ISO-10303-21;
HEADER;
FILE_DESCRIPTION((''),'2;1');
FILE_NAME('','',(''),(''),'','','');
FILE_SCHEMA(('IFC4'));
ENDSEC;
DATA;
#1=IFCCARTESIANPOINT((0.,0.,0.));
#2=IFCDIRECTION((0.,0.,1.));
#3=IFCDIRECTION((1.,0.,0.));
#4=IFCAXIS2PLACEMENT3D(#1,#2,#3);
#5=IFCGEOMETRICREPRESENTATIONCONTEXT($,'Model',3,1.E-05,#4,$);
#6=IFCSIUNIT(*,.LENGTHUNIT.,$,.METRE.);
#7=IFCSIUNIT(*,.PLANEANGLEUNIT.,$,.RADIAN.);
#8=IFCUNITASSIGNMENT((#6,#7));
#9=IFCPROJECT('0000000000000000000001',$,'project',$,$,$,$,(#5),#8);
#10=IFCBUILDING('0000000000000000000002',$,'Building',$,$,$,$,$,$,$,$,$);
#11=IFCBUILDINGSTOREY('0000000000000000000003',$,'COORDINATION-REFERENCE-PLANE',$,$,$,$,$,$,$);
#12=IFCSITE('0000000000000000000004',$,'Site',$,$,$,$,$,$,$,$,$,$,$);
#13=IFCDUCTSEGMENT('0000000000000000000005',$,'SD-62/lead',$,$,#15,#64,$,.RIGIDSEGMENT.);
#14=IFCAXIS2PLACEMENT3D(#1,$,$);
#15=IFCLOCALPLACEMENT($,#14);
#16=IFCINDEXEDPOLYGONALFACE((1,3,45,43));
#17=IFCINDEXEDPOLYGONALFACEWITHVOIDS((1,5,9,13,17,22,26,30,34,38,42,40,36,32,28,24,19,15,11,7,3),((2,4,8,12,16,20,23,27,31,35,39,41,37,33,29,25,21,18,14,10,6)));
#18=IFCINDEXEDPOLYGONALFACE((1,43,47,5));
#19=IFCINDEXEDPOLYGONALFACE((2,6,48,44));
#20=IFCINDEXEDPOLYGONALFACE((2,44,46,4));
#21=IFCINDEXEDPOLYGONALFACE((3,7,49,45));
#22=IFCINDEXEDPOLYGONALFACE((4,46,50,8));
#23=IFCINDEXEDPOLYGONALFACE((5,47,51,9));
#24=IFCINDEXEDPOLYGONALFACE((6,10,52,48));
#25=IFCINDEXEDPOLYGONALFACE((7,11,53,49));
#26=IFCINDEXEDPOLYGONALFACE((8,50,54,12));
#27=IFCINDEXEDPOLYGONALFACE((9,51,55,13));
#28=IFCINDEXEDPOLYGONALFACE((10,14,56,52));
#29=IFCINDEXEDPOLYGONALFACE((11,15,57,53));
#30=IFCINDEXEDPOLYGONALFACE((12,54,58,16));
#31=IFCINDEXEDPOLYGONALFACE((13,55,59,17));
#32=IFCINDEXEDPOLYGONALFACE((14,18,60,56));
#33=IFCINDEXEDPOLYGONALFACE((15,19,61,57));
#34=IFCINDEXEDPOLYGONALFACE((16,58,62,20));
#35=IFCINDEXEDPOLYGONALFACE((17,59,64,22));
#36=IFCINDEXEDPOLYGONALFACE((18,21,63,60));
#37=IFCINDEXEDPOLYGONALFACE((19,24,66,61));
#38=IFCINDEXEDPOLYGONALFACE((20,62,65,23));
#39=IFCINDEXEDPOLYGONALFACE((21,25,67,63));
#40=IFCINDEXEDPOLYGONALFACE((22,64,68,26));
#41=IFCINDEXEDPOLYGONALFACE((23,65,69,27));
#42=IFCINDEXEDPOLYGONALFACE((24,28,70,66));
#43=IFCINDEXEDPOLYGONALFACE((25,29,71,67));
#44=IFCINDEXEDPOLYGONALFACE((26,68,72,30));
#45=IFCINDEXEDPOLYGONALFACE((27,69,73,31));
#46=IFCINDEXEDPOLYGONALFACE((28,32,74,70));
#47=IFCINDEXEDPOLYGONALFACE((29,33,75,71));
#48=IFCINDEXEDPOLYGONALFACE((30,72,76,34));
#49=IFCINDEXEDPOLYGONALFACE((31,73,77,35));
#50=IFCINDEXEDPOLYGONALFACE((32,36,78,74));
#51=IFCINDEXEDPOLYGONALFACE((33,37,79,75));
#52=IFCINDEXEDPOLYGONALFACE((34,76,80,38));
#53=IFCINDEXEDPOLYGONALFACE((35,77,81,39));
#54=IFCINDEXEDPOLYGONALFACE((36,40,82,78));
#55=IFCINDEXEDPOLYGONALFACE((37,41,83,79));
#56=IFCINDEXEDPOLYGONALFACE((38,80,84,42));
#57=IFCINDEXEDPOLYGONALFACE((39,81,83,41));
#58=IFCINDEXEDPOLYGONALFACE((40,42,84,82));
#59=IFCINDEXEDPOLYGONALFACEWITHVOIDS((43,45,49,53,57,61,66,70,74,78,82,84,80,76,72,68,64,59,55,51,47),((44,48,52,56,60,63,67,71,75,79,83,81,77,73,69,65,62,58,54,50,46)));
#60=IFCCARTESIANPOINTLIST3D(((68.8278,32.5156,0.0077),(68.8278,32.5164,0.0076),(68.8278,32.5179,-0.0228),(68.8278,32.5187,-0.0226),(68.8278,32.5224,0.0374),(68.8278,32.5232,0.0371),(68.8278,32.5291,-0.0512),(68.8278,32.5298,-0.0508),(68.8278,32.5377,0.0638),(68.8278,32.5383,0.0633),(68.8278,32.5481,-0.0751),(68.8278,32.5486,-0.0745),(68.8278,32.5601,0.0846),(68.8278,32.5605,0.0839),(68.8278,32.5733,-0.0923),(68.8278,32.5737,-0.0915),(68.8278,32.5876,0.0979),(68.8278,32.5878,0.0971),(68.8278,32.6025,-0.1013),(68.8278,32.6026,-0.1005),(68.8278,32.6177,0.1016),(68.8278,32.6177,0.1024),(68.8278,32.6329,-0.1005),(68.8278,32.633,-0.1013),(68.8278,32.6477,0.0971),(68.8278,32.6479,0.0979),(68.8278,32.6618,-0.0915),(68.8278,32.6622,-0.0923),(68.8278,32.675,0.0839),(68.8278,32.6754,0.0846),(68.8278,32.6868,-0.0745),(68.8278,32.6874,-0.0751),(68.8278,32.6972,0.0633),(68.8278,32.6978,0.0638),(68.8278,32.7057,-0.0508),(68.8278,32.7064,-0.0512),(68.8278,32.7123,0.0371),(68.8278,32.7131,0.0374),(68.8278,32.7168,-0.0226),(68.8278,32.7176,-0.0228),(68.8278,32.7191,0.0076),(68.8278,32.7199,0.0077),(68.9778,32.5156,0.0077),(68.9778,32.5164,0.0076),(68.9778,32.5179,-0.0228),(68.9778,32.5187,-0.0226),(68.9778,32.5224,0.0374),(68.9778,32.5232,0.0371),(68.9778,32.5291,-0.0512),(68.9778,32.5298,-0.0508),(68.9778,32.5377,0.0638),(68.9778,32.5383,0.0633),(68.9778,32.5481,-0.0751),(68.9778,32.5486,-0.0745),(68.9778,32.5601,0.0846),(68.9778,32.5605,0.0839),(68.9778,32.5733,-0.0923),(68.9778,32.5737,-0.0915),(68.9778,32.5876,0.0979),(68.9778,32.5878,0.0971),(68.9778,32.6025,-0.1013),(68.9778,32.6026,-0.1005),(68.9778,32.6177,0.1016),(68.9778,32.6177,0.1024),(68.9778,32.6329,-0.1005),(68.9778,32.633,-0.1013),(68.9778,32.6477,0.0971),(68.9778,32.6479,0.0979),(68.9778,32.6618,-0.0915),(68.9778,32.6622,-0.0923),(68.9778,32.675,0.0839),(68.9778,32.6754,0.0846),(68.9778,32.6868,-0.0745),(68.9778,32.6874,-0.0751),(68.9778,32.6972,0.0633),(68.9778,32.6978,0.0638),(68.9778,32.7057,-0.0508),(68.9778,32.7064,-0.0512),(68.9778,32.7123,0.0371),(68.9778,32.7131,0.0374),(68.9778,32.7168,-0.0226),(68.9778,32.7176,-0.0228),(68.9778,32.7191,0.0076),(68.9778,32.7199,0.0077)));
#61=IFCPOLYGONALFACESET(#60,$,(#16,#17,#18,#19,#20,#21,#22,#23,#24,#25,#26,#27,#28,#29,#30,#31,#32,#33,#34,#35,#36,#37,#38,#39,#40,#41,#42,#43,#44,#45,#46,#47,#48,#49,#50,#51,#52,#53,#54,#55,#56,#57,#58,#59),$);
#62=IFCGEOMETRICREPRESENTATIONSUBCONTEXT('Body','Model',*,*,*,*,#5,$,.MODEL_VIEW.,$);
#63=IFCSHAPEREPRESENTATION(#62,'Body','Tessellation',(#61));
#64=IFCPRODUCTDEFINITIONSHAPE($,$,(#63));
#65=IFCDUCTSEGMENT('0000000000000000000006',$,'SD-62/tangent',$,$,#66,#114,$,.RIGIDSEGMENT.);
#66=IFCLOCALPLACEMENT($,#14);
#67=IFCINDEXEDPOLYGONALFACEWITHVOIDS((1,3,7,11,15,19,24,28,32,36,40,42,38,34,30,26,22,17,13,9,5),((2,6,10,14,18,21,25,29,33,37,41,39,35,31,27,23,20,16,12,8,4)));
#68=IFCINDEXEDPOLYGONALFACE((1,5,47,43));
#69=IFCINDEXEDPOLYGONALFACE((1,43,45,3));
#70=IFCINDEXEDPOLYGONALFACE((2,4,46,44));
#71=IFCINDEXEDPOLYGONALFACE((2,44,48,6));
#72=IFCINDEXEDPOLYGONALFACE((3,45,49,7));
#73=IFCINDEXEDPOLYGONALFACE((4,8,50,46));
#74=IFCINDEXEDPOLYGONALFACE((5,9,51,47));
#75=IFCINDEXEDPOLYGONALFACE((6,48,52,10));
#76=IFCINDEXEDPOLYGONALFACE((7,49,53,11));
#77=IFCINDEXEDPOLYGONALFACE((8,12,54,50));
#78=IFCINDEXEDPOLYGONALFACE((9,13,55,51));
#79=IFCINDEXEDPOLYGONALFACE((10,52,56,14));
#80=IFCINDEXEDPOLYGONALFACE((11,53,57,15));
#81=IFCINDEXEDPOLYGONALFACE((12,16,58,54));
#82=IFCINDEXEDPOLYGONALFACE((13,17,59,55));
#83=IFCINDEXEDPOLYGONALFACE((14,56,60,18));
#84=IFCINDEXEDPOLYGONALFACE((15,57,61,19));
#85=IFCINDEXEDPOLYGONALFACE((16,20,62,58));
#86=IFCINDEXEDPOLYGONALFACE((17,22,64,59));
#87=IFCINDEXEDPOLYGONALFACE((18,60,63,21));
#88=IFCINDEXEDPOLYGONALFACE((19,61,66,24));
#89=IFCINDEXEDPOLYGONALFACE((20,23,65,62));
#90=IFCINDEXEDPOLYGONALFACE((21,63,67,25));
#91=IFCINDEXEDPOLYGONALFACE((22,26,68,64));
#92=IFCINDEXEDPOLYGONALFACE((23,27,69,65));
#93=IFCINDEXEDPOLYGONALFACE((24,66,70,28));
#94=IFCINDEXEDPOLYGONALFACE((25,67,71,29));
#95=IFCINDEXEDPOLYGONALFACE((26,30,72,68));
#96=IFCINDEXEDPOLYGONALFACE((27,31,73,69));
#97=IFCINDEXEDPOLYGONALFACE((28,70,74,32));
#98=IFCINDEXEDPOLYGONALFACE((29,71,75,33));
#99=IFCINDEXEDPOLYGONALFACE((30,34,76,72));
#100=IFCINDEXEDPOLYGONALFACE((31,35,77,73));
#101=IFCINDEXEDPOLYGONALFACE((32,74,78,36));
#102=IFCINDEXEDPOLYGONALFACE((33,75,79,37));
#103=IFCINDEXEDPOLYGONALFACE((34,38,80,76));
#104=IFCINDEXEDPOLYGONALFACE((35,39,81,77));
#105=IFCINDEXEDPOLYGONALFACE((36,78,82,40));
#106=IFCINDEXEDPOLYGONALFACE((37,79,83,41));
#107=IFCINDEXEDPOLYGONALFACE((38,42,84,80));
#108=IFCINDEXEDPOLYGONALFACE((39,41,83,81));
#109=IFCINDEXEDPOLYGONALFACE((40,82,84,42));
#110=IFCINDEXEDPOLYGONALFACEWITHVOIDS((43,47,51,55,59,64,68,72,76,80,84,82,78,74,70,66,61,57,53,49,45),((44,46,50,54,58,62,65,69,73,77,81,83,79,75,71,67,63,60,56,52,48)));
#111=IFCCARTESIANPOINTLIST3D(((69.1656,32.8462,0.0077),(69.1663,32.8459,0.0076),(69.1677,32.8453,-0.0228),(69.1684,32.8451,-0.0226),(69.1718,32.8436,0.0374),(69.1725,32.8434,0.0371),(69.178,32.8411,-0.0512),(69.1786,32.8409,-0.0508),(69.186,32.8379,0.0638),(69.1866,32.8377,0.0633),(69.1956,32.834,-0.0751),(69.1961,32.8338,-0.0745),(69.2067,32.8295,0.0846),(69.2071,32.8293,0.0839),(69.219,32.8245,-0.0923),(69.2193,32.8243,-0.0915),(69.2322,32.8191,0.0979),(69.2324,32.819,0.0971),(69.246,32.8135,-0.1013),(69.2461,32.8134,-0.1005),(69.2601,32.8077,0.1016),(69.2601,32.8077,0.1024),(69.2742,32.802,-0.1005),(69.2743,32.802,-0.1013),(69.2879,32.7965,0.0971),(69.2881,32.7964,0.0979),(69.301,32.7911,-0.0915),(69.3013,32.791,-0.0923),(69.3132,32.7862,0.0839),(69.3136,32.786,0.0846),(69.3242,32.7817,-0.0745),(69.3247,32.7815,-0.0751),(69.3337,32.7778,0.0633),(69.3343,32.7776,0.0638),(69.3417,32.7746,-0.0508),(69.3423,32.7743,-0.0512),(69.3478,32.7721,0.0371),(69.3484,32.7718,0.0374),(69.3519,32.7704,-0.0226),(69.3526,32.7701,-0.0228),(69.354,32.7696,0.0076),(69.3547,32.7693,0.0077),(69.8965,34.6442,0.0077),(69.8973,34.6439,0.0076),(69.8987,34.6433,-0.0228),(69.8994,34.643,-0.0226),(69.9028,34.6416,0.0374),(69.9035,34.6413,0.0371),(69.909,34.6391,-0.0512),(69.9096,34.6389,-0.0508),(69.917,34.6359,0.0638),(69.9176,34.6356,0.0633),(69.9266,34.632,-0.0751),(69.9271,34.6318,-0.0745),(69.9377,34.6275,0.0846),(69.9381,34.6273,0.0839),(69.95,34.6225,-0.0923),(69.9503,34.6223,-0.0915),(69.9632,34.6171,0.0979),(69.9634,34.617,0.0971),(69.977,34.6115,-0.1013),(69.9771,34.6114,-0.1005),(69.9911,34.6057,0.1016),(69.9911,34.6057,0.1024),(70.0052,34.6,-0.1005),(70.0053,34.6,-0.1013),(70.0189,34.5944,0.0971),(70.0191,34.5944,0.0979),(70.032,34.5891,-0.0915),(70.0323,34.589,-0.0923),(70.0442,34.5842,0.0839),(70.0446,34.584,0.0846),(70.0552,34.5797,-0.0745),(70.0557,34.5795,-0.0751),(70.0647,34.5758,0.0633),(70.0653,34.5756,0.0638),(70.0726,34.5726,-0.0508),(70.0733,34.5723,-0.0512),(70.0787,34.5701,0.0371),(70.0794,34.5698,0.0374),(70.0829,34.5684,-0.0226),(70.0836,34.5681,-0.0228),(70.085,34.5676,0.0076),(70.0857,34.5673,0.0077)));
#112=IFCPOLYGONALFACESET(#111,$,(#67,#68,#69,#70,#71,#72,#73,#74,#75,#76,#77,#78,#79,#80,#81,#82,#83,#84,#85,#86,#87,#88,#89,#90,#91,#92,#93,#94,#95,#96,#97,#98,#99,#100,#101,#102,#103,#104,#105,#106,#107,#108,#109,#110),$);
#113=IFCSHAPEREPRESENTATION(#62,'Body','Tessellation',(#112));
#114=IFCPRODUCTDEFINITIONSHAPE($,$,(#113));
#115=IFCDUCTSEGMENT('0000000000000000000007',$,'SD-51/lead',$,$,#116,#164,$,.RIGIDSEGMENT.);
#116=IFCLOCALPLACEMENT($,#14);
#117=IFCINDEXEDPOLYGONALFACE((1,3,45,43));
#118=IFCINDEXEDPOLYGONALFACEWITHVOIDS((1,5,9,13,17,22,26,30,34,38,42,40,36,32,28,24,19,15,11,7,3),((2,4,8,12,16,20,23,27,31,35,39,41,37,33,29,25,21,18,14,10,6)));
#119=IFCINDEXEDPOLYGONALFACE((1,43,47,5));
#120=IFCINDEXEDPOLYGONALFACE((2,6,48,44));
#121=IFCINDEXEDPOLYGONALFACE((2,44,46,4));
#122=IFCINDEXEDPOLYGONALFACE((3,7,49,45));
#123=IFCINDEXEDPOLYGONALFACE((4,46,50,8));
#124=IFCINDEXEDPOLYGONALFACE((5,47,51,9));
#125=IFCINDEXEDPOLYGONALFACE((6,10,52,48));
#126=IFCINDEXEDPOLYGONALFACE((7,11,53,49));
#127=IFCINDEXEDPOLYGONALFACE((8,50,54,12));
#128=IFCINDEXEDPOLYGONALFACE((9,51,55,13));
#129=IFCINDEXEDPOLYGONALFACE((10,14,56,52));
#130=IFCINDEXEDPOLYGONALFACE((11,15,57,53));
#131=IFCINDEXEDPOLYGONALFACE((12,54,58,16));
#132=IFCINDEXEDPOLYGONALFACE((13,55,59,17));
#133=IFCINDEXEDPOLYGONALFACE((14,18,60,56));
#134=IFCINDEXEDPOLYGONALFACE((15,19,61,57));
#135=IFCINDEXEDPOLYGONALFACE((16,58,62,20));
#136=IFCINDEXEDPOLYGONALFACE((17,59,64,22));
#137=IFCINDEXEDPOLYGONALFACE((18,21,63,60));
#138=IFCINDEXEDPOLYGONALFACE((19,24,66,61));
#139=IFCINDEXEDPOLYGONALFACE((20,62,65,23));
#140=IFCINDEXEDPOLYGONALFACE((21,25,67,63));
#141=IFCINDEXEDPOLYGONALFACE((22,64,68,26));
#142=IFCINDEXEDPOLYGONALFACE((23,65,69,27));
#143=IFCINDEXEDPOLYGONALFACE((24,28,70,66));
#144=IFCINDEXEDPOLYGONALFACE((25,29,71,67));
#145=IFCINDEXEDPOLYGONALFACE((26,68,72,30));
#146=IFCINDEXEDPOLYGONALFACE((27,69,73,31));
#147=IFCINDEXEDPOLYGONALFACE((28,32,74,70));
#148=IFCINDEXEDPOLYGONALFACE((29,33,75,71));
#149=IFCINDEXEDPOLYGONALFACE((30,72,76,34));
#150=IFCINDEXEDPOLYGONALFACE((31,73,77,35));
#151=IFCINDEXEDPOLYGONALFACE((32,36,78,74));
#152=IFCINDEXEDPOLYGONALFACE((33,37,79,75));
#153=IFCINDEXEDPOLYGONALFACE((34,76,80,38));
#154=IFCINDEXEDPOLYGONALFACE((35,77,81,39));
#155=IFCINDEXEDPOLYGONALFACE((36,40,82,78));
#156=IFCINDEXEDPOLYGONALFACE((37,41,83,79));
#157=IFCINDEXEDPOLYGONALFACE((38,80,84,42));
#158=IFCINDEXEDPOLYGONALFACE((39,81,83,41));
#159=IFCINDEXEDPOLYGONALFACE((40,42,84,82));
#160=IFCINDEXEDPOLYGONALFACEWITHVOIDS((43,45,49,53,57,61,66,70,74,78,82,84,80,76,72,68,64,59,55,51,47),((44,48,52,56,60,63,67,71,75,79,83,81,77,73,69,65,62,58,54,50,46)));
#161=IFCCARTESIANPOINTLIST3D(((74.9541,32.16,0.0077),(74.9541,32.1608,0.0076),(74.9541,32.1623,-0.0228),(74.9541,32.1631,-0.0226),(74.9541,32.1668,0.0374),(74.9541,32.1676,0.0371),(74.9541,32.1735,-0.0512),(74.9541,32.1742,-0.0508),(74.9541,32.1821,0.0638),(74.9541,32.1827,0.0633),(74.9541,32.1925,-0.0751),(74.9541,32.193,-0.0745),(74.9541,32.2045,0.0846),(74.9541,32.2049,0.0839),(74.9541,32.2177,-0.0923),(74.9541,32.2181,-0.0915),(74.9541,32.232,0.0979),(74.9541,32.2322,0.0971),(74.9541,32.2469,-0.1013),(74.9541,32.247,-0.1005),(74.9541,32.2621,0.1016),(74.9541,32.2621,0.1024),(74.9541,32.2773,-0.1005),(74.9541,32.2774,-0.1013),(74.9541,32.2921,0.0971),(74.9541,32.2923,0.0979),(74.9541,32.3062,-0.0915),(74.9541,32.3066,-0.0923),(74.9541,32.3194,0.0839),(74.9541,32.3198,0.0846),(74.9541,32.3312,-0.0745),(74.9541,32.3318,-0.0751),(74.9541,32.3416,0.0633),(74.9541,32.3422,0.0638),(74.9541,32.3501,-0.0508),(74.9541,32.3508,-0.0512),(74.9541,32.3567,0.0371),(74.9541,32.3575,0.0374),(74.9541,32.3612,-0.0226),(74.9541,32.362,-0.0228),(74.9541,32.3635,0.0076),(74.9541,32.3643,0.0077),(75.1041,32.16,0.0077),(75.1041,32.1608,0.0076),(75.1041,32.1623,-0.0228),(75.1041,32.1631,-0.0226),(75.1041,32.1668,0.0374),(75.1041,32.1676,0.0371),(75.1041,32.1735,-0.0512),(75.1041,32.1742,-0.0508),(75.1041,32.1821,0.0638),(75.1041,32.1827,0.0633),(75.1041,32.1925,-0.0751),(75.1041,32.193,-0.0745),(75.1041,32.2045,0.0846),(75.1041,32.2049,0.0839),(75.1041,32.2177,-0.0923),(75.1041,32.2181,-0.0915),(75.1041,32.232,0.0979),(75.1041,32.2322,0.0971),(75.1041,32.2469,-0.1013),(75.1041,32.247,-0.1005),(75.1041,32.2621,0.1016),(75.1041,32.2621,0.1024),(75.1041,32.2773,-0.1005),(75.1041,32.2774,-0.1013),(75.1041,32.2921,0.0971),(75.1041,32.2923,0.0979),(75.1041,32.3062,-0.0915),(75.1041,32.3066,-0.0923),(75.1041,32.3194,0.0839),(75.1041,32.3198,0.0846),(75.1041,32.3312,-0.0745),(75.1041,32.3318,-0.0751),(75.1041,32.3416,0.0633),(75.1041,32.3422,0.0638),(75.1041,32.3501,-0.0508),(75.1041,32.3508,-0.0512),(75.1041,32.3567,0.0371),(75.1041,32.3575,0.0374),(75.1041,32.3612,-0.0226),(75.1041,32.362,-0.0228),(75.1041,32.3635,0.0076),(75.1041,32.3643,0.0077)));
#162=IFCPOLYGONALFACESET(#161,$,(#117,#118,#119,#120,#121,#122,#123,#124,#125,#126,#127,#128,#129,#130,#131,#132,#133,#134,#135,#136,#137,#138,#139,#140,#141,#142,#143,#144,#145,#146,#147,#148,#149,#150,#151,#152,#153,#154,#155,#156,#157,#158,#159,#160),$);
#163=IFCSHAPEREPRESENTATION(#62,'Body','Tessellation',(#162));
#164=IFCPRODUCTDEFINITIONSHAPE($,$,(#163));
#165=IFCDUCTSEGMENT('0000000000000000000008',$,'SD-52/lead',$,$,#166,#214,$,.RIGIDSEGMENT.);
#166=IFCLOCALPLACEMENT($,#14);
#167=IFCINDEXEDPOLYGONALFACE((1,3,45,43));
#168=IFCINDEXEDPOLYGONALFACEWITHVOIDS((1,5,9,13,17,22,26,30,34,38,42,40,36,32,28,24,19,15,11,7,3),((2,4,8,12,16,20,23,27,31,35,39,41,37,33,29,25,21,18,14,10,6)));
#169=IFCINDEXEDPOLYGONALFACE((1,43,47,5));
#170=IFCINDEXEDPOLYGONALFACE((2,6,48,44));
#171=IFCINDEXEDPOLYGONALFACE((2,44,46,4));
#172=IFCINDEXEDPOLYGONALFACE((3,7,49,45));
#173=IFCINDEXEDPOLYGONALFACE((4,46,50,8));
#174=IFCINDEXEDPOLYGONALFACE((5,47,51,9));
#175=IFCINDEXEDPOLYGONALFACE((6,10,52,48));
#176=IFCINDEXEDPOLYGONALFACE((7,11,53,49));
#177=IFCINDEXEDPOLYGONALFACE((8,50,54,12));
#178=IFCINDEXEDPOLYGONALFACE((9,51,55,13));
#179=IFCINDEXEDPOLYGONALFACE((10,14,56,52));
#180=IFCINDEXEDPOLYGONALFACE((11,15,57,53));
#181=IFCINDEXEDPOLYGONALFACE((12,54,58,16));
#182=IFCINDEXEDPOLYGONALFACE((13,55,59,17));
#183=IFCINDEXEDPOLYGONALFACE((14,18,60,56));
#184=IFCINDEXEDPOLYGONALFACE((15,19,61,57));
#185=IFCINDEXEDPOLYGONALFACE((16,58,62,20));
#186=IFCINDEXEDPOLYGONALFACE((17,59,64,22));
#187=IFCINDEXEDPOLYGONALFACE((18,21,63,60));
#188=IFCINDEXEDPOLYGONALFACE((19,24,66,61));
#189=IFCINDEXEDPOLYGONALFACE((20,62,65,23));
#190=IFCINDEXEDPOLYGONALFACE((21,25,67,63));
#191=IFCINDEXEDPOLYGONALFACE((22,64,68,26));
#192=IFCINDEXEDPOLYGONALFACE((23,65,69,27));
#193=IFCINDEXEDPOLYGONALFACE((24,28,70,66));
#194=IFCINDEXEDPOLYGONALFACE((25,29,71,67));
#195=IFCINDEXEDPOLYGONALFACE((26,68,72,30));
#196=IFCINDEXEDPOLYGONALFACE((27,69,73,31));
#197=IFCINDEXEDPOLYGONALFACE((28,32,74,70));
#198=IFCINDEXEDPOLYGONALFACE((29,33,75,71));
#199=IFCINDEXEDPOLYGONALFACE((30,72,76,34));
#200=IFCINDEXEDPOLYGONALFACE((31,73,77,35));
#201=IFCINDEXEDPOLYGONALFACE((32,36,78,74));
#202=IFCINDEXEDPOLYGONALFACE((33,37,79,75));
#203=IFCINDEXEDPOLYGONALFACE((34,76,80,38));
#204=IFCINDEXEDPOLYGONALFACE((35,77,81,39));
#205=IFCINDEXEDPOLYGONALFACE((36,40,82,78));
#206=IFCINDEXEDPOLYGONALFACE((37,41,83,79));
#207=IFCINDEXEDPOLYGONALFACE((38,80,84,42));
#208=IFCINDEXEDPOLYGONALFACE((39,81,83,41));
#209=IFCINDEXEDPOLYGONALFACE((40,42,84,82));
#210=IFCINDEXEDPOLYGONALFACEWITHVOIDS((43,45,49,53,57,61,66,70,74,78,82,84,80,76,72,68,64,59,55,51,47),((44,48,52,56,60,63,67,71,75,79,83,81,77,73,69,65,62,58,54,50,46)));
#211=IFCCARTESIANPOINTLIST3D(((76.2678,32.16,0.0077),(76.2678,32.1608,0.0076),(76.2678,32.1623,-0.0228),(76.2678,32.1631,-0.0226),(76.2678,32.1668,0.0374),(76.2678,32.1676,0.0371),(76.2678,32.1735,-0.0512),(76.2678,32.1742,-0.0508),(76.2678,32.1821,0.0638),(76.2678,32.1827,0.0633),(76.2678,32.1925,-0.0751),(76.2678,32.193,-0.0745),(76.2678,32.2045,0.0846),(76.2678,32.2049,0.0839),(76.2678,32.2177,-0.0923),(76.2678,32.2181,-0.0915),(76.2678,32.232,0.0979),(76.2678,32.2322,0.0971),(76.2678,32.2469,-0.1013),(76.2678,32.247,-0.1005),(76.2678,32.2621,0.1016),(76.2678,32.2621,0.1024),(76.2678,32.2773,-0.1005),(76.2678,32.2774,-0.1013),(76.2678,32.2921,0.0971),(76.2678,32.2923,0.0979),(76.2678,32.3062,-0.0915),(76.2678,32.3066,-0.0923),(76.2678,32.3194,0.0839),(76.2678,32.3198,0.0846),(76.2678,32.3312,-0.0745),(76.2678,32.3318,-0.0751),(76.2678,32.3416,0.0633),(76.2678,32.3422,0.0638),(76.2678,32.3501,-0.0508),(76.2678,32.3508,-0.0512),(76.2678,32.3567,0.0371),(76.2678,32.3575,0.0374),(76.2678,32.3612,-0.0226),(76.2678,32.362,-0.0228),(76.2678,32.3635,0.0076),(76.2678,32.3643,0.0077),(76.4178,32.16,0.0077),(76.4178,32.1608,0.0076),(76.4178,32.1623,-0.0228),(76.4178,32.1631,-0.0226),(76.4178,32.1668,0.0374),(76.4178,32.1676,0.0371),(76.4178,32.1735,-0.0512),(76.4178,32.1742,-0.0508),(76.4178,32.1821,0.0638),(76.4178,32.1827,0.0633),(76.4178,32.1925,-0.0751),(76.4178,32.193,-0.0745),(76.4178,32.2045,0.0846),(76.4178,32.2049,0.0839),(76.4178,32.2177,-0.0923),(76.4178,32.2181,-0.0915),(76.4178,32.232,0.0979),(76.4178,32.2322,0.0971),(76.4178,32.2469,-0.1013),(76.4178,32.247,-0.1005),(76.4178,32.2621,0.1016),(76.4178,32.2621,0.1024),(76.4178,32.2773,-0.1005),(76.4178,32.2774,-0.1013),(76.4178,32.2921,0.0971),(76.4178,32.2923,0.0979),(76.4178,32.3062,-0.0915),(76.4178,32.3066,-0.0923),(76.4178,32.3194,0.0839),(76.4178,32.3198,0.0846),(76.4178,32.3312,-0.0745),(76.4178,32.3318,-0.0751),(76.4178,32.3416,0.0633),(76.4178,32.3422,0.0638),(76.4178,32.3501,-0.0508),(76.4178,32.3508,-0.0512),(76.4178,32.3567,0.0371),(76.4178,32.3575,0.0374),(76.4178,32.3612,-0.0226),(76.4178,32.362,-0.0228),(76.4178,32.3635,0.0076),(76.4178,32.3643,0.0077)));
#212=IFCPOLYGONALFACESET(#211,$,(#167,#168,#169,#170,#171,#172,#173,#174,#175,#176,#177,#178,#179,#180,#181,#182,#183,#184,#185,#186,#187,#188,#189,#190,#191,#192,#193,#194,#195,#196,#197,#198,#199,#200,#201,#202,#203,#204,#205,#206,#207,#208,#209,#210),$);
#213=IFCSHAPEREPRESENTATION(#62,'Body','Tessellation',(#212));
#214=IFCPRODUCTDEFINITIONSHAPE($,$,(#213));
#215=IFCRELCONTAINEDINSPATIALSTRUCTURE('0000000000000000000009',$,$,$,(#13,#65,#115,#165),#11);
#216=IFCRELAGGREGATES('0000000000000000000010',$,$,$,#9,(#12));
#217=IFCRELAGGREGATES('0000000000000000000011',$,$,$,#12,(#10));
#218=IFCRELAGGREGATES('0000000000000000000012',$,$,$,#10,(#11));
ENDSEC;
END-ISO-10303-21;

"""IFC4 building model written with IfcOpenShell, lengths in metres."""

from ifc_helpers import new_model, si_unit, frame, origin_with_axes, place, context, subcontext, project, spatial, hollow_circle, extrude, element, save


model = new_model("IFC4")

# Units and contexts
model_context = context("Model", 3, precision=1e-05, world=origin_with_axes())
body_context_1 = subcontext(model_context, "Body", "Model", "MODEL_VIEW")
ifc_project = project(units=[si_unit("LENGTHUNIT", "METRE"), si_unit("PLANEANGLEUNIT", "RADIAN")], contexts=[model_context])

# Site, building, storey
site = spatial("IfcSite", under=ifc_project, Name="Site")
building = spatial("IfcBuilding", under=site, Name="Building")
storey = spatial("IfcBuildingStorey", under=building, Name="COORDINATION-REFERENCE-PLANE")

# Duct segment
duct_segment_1_placement = place(None, frame((68.8278, 32.6177, 0.0), z_axis=(1.0, 0.0, 0.0), x_axis=(0.0, 0.0, 1.0)))
element("IfcDuctSegment", 1, at=duct_segment_1_placement, inside=storey, Name="SD-62/lead", PredefinedType="RIGIDSEGMENT", context=body_context_1, shape_type="SweptSolid", body=[
    extrude(hollow_circle(Radius=0.1024, WallThickness=0.0008), origin_with_axes(), (0.0, 0.0, 1.0), 0.15),
])

# Duct segment
duct_segment_2_placement = place(None, frame((69.2601, 32.8077, 0.0), z_axis=(0.376625, 0.926366, 0.0), x_axis=(0.0, 0.0, 1.0)))
element("IfcDuctSegment", 2, at=duct_segment_2_placement, inside=storey, Name="SD-62/tangent", PredefinedType="RIGIDSEGMENT", context=body_context_1, shape_type="SweptSolid", body=[
    extrude(hollow_circle(Radius=0.1024, WallThickness=0.0008), origin_with_axes(), (0.0, 0.0, 1.0), 1.9409),
])

# Duct segments
for number, where, z_axis, x_axis, name in (
    (3, (75.1041, 32.2621, 0.0), (-1.0, 0.0, 0.0), (0.0, 0.0, 1.0), "SD-51/lead"),
    (4, (76.2678, 32.2621, 0.0), (1.0, 0.0, 0.0), (0.0, 0.0, 1.0), "SD-52/lead"),
):
    element("IfcDuctSegment", number, at=place(None, frame(where, z_axis=z_axis, x_axis=x_axis)), inside=storey, Name=name, PredefinedType="RIGIDSEGMENT", context=body_context_1, shape_type="SweptSolid", body=[
        extrude(hollow_circle(Radius=0.1024, WallThickness=0.0008), origin_with_axes(), (0.0, 0.0, 1.0), 0.15),
    ])

save(model, "model.ifc")
